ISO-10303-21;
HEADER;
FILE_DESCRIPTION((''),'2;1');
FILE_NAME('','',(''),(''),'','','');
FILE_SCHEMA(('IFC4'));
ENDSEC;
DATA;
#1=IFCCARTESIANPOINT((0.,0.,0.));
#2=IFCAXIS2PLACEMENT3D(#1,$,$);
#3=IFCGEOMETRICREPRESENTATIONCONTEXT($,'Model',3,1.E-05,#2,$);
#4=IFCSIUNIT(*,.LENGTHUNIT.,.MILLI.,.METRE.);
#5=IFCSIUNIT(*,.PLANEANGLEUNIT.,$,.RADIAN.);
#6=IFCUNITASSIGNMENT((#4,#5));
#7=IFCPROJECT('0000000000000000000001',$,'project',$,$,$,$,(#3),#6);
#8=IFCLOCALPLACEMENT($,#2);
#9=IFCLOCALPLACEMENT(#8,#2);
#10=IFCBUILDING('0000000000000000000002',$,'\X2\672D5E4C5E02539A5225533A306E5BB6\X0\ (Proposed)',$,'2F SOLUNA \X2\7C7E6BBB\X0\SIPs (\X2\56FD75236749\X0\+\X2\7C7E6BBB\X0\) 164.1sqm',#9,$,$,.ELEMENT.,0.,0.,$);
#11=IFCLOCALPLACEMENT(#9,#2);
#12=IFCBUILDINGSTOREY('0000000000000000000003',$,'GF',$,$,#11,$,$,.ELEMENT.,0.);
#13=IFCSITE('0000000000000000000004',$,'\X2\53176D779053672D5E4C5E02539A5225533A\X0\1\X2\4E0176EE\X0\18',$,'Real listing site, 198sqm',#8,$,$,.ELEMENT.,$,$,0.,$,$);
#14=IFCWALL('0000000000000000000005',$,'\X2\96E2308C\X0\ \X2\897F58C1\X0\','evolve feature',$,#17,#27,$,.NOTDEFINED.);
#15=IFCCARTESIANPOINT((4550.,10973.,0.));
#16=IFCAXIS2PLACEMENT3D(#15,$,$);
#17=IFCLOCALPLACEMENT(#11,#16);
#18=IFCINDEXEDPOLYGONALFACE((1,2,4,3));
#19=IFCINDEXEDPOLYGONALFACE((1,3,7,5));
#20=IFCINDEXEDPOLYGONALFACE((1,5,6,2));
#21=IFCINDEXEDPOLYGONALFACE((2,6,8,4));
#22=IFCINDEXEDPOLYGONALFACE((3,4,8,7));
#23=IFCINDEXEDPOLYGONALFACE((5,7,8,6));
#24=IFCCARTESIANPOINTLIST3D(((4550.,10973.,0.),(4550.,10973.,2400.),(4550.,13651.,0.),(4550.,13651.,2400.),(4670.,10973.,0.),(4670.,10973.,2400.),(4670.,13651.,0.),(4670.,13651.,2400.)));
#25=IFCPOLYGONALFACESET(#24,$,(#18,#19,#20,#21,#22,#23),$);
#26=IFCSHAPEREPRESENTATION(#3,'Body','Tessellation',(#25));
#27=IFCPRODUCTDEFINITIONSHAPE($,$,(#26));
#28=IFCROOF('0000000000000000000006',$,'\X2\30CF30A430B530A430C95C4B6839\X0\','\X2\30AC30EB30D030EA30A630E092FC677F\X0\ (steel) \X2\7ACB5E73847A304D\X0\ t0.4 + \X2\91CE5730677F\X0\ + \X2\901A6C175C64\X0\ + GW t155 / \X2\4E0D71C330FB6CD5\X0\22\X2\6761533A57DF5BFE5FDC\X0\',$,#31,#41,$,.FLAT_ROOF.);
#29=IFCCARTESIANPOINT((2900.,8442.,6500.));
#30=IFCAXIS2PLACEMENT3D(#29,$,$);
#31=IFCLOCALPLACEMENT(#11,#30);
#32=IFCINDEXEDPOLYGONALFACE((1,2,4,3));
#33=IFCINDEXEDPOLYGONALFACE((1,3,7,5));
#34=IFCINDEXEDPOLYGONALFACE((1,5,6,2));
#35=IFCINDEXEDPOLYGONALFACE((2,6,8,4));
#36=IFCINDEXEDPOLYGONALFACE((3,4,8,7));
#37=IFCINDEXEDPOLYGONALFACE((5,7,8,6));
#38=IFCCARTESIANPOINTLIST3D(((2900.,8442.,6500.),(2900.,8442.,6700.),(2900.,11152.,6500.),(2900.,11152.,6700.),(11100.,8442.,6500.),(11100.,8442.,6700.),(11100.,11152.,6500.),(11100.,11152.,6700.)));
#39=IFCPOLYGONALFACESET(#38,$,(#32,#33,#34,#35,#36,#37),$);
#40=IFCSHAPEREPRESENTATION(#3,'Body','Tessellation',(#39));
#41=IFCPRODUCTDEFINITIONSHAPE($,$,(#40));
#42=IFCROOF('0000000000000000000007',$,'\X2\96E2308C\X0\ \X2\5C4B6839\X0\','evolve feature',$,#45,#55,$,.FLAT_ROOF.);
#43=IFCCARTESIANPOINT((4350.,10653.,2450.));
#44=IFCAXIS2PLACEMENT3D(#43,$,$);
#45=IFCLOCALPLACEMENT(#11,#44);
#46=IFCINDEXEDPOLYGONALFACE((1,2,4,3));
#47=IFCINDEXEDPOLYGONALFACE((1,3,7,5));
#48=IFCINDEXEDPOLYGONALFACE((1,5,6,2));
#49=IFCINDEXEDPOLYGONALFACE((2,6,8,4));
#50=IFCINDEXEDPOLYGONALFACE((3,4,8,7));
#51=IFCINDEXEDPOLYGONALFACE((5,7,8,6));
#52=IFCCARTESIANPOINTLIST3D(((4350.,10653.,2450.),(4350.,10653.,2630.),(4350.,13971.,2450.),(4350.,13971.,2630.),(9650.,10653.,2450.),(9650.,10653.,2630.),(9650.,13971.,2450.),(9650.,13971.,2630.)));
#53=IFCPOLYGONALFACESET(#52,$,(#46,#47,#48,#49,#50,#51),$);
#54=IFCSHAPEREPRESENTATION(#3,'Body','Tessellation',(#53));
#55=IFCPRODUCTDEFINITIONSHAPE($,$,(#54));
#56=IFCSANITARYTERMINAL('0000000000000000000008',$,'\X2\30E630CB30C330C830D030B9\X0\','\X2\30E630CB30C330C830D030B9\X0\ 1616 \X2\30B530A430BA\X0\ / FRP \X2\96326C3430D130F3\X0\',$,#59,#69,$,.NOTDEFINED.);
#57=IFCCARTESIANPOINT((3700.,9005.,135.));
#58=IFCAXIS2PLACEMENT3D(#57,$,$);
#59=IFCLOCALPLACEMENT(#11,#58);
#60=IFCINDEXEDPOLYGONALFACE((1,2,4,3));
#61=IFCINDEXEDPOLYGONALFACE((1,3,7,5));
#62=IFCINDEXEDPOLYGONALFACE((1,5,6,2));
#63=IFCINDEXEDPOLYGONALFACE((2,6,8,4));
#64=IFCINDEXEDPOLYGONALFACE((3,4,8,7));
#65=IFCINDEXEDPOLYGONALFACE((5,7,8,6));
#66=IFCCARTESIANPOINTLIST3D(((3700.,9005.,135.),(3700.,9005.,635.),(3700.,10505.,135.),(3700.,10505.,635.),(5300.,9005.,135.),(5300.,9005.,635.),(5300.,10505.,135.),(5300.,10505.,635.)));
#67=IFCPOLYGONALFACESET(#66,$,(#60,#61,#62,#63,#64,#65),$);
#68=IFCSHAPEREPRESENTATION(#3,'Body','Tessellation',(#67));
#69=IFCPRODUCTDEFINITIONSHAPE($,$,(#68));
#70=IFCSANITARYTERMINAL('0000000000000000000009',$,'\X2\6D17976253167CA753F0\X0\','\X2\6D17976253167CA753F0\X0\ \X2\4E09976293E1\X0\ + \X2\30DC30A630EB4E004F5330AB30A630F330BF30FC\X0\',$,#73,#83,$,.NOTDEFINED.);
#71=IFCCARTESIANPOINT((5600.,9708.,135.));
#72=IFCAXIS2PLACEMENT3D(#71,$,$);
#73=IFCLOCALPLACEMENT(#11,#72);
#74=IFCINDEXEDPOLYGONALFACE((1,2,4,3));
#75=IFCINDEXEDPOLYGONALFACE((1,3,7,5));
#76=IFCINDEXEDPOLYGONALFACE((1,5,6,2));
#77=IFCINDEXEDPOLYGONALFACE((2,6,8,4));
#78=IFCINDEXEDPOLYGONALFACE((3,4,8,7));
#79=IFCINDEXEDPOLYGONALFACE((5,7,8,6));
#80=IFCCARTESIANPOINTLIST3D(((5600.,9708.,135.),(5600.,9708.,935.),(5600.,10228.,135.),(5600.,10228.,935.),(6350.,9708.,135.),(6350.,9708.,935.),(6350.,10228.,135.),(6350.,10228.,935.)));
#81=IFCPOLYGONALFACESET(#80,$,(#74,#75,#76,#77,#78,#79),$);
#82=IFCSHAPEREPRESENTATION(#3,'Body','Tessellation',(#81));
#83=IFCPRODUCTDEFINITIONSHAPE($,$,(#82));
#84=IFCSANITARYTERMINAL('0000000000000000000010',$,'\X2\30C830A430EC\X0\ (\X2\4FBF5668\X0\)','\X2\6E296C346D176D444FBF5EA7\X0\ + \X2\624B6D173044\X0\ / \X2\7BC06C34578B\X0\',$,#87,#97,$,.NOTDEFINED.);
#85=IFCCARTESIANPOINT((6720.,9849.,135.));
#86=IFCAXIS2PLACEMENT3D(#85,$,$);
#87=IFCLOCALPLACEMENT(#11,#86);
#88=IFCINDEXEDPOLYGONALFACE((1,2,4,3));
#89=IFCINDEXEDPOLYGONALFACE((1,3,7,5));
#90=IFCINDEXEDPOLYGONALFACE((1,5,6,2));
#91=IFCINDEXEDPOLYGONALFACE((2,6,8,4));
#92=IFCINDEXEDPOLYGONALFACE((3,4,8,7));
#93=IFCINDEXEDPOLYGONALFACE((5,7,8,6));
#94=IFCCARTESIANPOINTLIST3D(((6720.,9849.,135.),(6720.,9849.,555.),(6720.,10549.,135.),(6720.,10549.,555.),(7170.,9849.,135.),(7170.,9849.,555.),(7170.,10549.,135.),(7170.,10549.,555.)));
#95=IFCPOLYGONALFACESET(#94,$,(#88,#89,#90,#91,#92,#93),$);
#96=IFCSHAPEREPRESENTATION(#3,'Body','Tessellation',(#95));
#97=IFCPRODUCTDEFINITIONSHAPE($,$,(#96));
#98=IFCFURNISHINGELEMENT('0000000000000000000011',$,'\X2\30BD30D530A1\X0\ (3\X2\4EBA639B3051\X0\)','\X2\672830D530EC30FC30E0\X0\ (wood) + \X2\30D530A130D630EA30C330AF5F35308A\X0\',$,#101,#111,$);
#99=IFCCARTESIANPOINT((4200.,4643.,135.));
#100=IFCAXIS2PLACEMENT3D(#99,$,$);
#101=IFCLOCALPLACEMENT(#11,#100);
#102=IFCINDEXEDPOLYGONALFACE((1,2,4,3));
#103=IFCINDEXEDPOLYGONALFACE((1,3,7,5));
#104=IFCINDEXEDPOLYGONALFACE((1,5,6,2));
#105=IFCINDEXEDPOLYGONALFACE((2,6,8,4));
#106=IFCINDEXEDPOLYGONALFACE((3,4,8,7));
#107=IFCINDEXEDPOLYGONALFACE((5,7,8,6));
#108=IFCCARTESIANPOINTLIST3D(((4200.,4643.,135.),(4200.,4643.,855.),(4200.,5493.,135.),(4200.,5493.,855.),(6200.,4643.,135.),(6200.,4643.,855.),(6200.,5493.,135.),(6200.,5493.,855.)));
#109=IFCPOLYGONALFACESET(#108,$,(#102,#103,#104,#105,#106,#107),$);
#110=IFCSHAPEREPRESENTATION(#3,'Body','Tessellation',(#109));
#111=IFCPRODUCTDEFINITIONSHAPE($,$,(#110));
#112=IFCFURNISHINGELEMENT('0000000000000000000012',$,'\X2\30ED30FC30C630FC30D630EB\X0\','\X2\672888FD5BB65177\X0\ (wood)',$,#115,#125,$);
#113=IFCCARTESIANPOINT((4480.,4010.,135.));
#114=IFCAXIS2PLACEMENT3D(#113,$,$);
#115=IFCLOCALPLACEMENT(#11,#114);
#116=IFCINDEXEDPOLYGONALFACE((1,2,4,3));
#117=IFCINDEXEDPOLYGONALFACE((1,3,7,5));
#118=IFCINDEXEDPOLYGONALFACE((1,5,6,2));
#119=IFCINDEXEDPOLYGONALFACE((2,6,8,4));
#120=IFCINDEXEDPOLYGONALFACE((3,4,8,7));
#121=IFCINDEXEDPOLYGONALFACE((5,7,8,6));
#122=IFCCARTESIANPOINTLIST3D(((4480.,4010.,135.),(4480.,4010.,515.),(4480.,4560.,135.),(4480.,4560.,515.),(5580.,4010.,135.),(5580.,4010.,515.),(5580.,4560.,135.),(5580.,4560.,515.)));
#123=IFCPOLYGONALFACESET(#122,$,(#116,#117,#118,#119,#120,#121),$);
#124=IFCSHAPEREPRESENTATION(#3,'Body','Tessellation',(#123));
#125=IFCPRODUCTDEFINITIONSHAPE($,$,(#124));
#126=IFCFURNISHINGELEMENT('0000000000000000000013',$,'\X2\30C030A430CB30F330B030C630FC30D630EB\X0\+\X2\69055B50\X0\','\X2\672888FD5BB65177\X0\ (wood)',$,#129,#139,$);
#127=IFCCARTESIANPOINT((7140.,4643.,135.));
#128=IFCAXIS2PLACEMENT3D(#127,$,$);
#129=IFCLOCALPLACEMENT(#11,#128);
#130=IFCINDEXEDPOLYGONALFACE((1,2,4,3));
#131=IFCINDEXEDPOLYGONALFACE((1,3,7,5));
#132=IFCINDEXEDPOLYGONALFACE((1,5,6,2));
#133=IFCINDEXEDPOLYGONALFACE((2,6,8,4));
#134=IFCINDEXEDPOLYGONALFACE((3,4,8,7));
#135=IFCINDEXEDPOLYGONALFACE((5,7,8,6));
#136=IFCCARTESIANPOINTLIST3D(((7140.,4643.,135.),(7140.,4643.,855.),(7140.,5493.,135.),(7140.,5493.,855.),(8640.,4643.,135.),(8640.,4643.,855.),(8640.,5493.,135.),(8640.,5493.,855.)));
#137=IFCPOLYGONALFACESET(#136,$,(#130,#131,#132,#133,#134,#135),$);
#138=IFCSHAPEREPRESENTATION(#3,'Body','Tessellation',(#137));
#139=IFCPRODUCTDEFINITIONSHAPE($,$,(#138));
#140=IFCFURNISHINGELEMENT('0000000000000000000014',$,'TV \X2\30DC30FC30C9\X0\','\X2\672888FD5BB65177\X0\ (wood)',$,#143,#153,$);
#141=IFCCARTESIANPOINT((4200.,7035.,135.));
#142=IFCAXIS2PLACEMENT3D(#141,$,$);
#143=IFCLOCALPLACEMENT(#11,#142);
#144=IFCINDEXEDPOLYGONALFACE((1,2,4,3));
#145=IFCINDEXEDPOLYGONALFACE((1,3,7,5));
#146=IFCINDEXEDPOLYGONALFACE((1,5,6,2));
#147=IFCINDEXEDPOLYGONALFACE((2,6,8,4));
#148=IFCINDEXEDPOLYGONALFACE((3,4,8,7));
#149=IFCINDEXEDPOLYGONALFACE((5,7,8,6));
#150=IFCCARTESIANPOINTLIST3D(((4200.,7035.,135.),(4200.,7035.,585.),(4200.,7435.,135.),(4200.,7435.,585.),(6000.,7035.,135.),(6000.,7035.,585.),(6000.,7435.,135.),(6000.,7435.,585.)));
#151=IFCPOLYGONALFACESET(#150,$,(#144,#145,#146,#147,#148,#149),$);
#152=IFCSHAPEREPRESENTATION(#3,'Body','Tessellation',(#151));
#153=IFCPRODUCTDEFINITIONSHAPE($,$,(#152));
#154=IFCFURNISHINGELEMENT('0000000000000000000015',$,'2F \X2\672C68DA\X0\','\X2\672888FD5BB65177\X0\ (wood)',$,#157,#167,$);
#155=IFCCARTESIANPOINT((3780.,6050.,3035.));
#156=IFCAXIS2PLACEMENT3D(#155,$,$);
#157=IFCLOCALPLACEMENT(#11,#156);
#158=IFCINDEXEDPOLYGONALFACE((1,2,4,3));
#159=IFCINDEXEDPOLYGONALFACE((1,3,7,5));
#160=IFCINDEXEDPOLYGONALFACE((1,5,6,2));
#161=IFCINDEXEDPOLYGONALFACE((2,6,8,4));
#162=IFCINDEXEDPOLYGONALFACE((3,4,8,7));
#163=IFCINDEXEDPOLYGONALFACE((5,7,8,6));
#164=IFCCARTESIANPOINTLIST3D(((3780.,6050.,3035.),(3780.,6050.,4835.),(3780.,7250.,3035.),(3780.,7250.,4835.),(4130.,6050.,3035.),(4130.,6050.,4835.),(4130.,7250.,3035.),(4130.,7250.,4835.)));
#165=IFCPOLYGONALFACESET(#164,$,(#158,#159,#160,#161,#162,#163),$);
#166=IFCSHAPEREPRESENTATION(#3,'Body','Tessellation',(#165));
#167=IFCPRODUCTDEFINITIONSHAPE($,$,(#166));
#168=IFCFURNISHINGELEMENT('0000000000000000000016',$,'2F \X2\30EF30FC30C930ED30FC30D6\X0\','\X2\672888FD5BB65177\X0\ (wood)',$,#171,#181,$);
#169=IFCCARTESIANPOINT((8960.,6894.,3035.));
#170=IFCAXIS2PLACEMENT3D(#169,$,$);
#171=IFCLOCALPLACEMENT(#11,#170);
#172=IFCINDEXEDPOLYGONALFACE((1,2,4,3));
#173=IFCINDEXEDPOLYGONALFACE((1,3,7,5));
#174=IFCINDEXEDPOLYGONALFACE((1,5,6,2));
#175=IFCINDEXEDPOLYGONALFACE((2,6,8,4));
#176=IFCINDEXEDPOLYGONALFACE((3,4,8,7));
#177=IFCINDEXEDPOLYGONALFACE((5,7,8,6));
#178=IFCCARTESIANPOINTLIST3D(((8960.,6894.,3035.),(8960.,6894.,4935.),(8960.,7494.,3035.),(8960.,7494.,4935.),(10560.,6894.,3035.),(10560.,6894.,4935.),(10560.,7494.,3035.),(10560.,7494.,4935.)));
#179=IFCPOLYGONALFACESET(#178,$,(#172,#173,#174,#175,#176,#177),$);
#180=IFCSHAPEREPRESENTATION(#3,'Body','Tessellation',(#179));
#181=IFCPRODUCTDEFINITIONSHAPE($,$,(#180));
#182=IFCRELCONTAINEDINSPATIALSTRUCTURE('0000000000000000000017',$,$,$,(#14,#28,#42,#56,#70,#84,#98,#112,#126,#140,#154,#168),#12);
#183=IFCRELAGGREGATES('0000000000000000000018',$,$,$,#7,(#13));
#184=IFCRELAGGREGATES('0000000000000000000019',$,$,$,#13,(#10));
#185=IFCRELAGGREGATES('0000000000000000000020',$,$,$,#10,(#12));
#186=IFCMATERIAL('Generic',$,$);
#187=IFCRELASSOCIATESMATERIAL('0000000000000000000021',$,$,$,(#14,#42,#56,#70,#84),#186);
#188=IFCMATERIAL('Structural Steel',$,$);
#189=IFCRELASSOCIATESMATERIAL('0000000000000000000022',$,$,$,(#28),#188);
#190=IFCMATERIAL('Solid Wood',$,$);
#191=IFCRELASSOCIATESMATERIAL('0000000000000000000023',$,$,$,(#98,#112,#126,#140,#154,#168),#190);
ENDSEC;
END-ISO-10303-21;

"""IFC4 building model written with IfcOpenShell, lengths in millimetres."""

from ifc_helpers import new_model, si_unit, frame, frame_2d, origin, place, context, project, spatial, rectangle, extrude, material, element, save


model = new_model("IFC4")

# Units and contexts
model_context = context("Model", 3, precision=1e-05, world=origin())
ifc_project = project(units=[si_unit("LENGTHUNIT", "METRE", prefix="MILLI"), si_unit("PLANEANGLEUNIT", "RADIAN")], contexts=[model_context])

# Site, building, storey
site_placement = place(None, origin())
site = spatial("IfcSite", under=ifc_project, at=site_placement, Name="北海道札幌市厚別区1丁目18", ObjectType="Real listing site, 198sqm", CompositionType="ELEMENT", RefElevation=0.0)
building_placement = place(site_placement, origin())
building = spatial("IfcBuilding", under=site, at=building_placement, Name="札幌市厚別区の家 (Proposed)", ObjectType="2F SOLUNA 籾殻SIPs (国産杉+籾殻) 164.1sqm", CompositionType="ELEMENT", ElevationOfRefHeight=0.0, ElevationOfTerrain=0.0)
storey_placement = place(building_placement, origin())
storey = spatial("IfcBuildingStorey", under=building, at=storey_placement, Name="GF", CompositionType="ELEMENT", Elevation=0.0)

# Shared definitions
ifc_material_1 = material(Name="Generic")

# Shared definitions
ifc_material_2 = material(Name="Solid Wood")

# Wall
wall_1_placement = place(storey_placement, frame((4550.0, 10973.0, 0.0)))
element("IfcWall", 1, at=wall_1_placement, inside=storey, material=ifc_material_1, Name="離れ 西壁", Description="evolve feature", PredefinedType="NOTDEFINED", context=model_context, shape_type="SweptSolid", body=[
    extrude(rectangle(XDim=120.0, YDim=2678.0, at=frame_2d((60.0, 1339.0))), frame((4550.0, 10973.0, 0.0)), (0.0, 0.0, 1.0), 2400.0),
])

# Roofs
ifc_material_3 = material(Name="Structural Steel")
roof_1_placement = place(storey_placement, frame((2900.0, 8442.0, 6500.0)))
element("IfcRoof", 2, at=roof_1_placement, inside=storey, material=ifc_material_3, Name="ハイサイド屋根", Description="ガルバリウム鋼板 (steel) 立平葺き t0.4 + 野地板 + 通気層 + GW t155 / 不燃・法22条区域対応", PredefinedType="FLAT_ROOF", context=model_context, shape_type="SweptSolid", body=[
    extrude(rectangle(XDim=8200.0, YDim=2710.0, at=frame_2d((4100.0, 1355.0))), frame((2900.0, 8442.0, 6500.0)), (0.0, 0.0, 1.0), 200.0),
])
roof_2_placement = place(storey_placement, frame((4350.0, 10653.0, 2450.0)))
element("IfcRoof", 3, at=roof_2_placement, inside=storey, material=ifc_material_1, Name="離れ 屋根", Description="evolve feature", PredefinedType="FLAT_ROOF", context=model_context, shape_type="SweptSolid", body=[
    extrude(rectangle(XDim=5300.0, YDim=3318.0, at=frame_2d((2650.0, 1659.0))), frame((4350.0, 10653.0, 2450.0)), (0.0, 0.0, 1.0), 180.0),
])

# Sanitary terminals
sanitary_terminal_1_placement = place(storey_placement, frame((3700.0, 9005.0, 135.0)))
element("IfcSanitaryTerminal", 4, at=sanitary_terminal_1_placement, inside=storey, material=ifc_material_1, Name="ユニットバス", Description="ユニットバス 1616 サイズ / FRP 防水パン", PredefinedType="NOTDEFINED", context=model_context, shape_type="SweptSolid", body=[
    extrude(rectangle(XDim=1600.0, YDim=1500.0, at=frame_2d((800.0, 750.0))), frame((3700.0, 9005.0, 135.0)), (0.0, 0.0, 1.0), 500.0),
])
sanitary_terminal_2_placement = place(storey_placement, frame((5600.0, 9708.0, 135.0)))
element("IfcSanitaryTerminal", 5, at=sanitary_terminal_2_placement, inside=storey, material=ifc_material_1, Name="洗面化粧台", Description="洗面化粧台 三面鏡 + ボウル一体カウンター", PredefinedType="NOTDEFINED", context=model_context, shape_type="SweptSolid", body=[
    extrude(rectangle(XDim=750.0, YDim=520.0, at=frame_2d((375.0, 260.0))), frame((5600.0, 9708.0, 135.0)), (0.0, 0.0, 1.0), 800.0),
])
sanitary_terminal_3_placement = place(storey_placement, frame((6720.0, 9849.0, 135.0)))
element("IfcSanitaryTerminal", 6, at=sanitary_terminal_3_placement, inside=storey, material=ifc_material_1, Name="トイレ (便器)", Description="温水洗浄便座 + 手洗い / 節水型", PredefinedType="NOTDEFINED", context=model_context, shape_type="SweptSolid", body=[
    extrude(rectangle(XDim=450.0, YDim=700.0, at=frame_2d((225.0, 350.0))), frame((6720.0, 9849.0, 135.0)), (0.0, 0.0, 1.0), 420.0),
])

# Furnishing elements
furnishing_1_placement = place(storey_placement, frame((4200.0, 4643.0, 135.0)))
element("IfcFurnishingElement", 7, at=furnishing_1_placement, inside=storey, material=ifc_material_2, Name="ソファ (3人掛け)", Description="木フレーム (wood) + ファブリック張り", context=model_context, shape_type="SweptSolid", body=[
    extrude(rectangle(XDim=2000.0, YDim=850.0, at=frame_2d((1000.0, 425.0))), frame((4200.0, 4643.0, 135.0)), (0.0, 0.0, 1.0), 720.0),
])
furnishing_2_placement = place(storey_placement, frame((4480.0, 4010.0, 135.0)))
element("IfcFurnishingElement", 8, at=furnishing_2_placement, inside=storey, material=ifc_material_2, Name="ローテーブル", Description="木製家具 (wood)", context=model_context, shape_type="SweptSolid", body=[
    extrude(rectangle(XDim=1100.0, YDim=550.0, at=frame_2d((550.0, 275.0))), frame((4480.0, 4010.0, 135.0)), (0.0, 0.0, 1.0), 380.0),
])
furnishing_3_placement = place(storey_placement, frame((7140.0, 4643.0, 135.0)))
element("IfcFurnishingElement", 9, at=furnishing_3_placement, inside=storey, material=ifc_material_2, Name="ダイニングテーブル+椅子", Description="木製家具 (wood)", context=model_context, shape_type="SweptSolid", body=[
    extrude(rectangle(XDim=1500.0, YDim=850.0, at=frame_2d((750.0, 425.0))), frame((7140.0, 4643.0, 135.0)), (0.0, 0.0, 1.0), 720.0),
])
furnishing_4_placement = place(storey_placement, frame((4200.0, 7035.0, 135.0)))
element("IfcFurnishingElement", 10, at=furnishing_4_placement, inside=storey, material=ifc_material_2, Name="TV ボード", Description="木製家具 (wood)", context=model_context, shape_type="SweptSolid", body=[
    extrude(rectangle(XDim=1800.0, YDim=400.0, at=frame_2d((900.0, 200.0))), frame((4200.0, 7035.0, 135.0)), (0.0, 0.0, 1.0), 450.0),
])
furnishing_5_placement = place(storey_placement, frame((3780.0, 6050.0, 3035.0)))
element("IfcFurnishingElement", 11, at=furnishing_5_placement, inside=storey, material=ifc_material_2, Name="2F 本棚", Description="木製家具 (wood)", context=model_context, shape_type="SweptSolid", body=[
    extrude(rectangle(XDim=350.0, YDim=1200.0, at=frame_2d((175.0, 600.0))), frame((3780.0, 6050.0, 3035.0)), (0.0, 0.0, 1.0), 1800.0),
])
furnishing_6_placement = place(storey_placement, frame((8960.0, 6894.0, 3035.0)))
element("IfcFurnishingElement", 12, at=furnishing_6_placement, inside=storey, material=ifc_material_2, Name="2F ワードローブ", Description="木製家具 (wood)", context=model_context, shape_type="SweptSolid", body=[
    extrude(rectangle(XDim=1600.0, YDim=600.0, at=frame_2d((800.0, 300.0))), frame((8960.0, 6894.0, 3035.0)), (0.0, 0.0, 1.0), 1900.0),
])

save(model, "model.ifc")
